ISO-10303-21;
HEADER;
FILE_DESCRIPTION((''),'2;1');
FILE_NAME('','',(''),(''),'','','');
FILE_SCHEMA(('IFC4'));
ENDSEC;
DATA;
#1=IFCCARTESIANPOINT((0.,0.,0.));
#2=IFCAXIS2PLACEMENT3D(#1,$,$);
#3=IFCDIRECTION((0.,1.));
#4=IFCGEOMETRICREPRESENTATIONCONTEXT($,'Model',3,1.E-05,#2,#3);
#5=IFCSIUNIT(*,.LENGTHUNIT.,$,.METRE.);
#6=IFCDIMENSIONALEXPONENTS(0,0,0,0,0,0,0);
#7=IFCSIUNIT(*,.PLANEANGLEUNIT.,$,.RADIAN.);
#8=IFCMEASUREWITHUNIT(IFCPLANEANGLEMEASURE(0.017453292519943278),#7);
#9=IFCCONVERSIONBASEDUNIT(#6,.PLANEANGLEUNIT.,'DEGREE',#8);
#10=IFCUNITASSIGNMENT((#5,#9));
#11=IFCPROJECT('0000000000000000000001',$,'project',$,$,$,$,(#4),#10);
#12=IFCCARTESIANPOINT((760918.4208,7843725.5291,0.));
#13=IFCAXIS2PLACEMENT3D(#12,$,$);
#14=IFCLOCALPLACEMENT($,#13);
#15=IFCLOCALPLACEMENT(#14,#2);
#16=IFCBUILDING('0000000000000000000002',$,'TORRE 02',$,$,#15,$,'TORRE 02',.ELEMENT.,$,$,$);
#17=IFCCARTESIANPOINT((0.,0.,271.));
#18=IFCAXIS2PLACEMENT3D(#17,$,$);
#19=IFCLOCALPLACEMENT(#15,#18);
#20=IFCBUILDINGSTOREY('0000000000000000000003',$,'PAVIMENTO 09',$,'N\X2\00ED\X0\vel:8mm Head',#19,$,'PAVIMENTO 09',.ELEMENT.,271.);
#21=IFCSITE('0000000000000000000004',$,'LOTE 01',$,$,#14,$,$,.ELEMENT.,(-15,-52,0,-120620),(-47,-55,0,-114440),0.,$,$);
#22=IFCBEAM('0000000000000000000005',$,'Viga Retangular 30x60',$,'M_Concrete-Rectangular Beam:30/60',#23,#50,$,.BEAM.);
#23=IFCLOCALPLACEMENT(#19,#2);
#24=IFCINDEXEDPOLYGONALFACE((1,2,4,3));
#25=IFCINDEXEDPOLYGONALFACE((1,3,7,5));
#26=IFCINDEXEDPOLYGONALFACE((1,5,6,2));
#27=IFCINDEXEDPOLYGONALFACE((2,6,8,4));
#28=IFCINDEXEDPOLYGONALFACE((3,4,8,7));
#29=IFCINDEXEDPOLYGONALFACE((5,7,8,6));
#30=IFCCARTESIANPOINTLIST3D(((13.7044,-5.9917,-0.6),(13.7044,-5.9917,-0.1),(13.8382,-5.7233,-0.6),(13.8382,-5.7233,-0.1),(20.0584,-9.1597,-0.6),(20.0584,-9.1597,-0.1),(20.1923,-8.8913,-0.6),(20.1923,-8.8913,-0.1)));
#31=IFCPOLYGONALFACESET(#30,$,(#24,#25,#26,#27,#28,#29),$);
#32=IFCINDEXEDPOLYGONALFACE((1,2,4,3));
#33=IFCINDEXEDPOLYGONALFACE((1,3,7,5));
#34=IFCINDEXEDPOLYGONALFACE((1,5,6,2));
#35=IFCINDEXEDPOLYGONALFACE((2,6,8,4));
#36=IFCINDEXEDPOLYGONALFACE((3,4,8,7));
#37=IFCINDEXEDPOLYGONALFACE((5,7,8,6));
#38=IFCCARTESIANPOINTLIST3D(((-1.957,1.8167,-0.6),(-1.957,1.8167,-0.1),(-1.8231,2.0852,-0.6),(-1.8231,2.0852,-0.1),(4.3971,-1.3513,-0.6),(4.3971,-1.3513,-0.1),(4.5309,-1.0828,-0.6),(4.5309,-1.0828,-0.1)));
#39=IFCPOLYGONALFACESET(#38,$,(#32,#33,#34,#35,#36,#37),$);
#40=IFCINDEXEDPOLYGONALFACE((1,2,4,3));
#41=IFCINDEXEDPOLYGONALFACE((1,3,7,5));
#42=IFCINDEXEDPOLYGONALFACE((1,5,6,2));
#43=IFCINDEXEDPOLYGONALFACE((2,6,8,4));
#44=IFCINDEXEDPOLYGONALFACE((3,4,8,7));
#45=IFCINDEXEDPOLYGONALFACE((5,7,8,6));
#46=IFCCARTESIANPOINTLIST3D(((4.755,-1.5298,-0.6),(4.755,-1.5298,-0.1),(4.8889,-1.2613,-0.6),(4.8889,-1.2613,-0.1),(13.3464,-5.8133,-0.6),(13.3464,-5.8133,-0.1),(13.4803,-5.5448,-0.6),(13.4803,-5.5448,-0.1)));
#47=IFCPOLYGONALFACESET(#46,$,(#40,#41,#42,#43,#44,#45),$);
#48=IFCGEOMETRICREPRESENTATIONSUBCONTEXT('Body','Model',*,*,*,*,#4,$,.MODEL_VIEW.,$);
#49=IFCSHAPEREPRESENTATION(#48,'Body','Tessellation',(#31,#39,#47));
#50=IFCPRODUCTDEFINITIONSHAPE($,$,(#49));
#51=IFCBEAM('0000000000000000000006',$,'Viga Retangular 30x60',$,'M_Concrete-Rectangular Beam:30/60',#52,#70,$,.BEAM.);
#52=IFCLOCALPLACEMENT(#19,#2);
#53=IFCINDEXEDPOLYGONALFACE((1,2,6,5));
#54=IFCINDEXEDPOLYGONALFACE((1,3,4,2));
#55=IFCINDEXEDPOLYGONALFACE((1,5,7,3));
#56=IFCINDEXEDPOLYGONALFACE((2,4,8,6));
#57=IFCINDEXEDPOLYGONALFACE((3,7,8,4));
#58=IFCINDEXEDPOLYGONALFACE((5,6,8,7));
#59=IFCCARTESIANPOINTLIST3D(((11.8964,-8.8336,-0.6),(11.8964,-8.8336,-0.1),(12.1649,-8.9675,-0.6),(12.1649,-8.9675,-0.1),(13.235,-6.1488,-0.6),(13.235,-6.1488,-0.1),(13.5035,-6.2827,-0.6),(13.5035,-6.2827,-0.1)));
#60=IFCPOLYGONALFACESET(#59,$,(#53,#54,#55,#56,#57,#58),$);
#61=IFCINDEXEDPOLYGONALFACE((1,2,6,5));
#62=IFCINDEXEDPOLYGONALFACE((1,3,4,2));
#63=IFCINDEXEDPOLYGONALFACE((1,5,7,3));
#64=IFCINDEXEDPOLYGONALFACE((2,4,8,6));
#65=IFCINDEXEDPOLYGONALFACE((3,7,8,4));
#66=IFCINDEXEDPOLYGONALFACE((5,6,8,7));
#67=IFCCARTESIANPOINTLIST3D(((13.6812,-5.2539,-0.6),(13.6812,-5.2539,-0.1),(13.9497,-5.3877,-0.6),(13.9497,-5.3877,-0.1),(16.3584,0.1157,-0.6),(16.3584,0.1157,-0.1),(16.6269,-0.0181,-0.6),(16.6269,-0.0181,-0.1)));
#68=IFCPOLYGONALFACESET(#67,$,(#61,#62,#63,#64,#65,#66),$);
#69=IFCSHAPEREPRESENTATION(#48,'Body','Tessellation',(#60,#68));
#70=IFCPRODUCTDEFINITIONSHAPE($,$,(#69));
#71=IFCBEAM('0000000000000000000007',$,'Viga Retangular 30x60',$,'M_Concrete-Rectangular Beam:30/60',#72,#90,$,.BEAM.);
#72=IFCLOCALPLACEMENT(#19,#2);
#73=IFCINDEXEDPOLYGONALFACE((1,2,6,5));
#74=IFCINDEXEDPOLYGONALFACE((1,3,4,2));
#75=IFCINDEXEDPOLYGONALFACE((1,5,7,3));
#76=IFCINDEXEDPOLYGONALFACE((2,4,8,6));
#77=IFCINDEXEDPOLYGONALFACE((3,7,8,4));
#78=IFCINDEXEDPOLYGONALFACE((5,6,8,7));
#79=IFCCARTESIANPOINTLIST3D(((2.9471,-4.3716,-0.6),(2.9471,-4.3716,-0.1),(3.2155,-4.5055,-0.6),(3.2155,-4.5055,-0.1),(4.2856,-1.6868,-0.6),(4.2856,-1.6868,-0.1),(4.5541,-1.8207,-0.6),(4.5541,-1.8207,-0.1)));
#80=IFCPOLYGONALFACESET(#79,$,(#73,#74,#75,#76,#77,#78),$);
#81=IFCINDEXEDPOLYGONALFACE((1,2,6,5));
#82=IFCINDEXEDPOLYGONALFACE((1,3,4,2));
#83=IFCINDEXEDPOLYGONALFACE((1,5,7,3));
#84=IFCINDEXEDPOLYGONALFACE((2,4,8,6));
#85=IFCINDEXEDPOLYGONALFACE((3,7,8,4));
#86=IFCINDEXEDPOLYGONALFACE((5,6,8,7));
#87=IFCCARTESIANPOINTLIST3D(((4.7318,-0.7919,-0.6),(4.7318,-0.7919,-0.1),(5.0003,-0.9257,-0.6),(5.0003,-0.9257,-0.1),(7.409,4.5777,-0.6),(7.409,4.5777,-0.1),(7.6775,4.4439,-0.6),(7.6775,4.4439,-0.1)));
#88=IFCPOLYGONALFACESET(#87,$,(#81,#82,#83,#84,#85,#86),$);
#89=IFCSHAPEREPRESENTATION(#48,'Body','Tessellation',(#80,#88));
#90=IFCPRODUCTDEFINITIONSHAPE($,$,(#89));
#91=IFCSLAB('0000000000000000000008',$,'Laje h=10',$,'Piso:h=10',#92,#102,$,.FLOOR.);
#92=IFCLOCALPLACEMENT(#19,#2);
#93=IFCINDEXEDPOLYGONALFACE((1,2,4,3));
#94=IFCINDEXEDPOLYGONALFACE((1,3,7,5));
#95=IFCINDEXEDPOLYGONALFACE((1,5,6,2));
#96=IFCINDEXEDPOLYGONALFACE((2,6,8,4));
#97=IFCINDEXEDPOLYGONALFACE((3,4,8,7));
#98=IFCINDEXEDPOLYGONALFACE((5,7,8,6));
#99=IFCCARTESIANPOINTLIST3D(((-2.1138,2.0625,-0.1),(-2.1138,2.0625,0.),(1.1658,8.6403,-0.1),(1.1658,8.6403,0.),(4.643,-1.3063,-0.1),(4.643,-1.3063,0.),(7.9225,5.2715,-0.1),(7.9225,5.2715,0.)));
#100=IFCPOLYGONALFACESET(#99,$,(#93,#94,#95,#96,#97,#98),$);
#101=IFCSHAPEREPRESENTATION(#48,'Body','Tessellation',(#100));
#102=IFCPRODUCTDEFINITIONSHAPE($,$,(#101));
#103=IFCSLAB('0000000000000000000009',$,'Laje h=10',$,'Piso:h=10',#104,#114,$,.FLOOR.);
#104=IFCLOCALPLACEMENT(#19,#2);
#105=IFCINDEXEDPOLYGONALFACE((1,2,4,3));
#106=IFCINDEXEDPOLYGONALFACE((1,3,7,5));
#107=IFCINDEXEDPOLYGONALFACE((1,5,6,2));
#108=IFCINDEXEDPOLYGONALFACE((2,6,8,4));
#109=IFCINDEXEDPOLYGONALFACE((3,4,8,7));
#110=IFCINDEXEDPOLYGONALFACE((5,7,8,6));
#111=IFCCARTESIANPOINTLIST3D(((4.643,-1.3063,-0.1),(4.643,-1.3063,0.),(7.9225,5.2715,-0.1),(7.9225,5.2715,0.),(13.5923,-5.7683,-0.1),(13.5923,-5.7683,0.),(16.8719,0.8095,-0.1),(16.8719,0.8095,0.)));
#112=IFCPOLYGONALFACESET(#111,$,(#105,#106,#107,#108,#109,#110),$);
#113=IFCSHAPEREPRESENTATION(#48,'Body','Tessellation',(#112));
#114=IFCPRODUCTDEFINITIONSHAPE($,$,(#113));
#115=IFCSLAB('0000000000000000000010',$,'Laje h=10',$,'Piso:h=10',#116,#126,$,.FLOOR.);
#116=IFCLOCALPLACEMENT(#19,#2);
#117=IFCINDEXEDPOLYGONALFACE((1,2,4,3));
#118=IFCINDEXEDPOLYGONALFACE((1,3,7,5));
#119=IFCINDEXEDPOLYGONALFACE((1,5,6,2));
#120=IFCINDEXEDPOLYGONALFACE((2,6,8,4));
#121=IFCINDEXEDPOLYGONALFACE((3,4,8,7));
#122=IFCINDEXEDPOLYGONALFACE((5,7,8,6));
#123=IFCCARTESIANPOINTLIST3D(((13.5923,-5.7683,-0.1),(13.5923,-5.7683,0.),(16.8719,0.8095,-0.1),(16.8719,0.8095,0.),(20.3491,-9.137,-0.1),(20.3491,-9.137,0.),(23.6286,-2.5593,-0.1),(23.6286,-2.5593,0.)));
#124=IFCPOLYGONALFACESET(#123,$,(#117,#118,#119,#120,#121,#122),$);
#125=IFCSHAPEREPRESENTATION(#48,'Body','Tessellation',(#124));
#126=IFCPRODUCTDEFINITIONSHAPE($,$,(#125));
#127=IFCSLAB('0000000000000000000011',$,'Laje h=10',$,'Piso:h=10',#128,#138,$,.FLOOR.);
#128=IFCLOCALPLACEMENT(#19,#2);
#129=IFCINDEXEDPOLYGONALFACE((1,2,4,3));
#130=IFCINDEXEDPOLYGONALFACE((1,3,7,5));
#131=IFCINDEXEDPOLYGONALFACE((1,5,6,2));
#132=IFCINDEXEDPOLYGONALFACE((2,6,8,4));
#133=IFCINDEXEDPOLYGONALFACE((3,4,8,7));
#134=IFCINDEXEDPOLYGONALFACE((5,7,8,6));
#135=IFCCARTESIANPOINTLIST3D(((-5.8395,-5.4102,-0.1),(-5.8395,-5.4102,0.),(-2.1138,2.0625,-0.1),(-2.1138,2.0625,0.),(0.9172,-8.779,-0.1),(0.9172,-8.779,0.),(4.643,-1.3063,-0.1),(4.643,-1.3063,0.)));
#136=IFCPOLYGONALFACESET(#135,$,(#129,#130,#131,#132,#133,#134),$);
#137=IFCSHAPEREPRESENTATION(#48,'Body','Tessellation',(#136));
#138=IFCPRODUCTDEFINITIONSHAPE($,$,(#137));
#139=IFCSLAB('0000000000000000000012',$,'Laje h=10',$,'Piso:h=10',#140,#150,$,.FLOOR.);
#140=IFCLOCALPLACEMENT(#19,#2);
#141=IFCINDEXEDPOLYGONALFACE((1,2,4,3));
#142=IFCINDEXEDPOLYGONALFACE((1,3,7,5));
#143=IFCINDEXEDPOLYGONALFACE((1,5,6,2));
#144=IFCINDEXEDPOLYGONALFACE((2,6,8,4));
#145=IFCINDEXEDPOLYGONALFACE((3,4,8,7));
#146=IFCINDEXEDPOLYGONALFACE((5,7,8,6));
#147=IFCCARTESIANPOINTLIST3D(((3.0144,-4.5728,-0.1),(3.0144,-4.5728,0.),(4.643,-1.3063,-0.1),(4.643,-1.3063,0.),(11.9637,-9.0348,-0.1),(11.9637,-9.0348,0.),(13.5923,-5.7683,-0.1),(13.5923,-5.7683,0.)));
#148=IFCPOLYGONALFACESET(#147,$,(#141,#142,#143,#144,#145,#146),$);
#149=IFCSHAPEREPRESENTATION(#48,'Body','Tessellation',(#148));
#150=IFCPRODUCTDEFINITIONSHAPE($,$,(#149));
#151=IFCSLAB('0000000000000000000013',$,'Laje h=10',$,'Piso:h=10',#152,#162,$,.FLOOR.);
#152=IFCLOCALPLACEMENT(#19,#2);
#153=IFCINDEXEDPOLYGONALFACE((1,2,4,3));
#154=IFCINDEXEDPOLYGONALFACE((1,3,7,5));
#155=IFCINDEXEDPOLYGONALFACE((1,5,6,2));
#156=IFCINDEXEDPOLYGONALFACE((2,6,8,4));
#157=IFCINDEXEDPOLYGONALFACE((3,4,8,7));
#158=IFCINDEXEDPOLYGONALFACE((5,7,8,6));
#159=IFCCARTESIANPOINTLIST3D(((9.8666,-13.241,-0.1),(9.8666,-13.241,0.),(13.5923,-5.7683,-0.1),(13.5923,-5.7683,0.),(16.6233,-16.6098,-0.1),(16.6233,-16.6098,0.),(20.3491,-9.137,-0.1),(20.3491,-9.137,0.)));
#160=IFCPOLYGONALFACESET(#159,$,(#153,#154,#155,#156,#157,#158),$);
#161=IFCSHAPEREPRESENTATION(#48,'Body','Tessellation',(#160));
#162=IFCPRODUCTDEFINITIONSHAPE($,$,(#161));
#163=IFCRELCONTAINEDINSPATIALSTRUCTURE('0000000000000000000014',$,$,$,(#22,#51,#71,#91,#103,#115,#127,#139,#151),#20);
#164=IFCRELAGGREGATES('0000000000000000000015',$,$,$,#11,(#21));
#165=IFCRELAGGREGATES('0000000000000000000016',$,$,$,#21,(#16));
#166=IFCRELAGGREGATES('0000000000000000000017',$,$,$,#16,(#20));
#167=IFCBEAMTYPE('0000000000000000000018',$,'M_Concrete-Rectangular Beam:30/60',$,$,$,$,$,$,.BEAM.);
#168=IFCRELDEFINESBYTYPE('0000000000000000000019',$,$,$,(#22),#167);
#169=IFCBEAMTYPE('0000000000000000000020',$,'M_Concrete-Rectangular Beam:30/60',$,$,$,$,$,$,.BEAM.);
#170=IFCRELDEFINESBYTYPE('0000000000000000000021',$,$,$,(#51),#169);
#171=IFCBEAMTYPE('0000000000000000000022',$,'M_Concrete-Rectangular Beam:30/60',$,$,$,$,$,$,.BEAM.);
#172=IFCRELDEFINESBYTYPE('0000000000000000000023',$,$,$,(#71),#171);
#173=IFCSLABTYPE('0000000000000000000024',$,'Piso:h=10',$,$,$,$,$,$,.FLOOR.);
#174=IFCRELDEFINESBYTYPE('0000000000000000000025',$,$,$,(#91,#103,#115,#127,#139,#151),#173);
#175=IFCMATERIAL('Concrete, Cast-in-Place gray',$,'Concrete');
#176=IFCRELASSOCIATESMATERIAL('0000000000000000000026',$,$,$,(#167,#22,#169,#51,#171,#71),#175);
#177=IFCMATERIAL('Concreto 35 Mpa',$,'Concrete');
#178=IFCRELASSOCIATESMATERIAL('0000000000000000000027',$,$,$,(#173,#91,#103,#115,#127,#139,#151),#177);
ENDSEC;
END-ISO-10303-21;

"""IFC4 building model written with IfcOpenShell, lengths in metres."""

from ifc_helpers import new_model, entity, si_unit, converted_unit, direction, frame, origin, place, context, subcontext, project, spatial, indexed_curve, outline, extrude, source, transform, mapped, material, type_object, type_shapes, element, save


model = new_model("IFC4")

# Units and contexts
model_context = context("Model", 3, precision=1e-05, world=origin(), true_north=direction((0.0, 1.0)))
body_context = subcontext(model_context, "Body", "Model", "MODEL_VIEW")
ifc_project = project(units=[si_unit("LENGTHUNIT", "METRE"), converted_unit("PLANEANGLEUNIT", "DEGREE", entity("IfcPlaneAngleMeasure", 0.017453292519943278), si_unit("PLANEANGLEUNIT", "RADIAN"), dimensions=[0, 0, 0, 0, 0, 0, 0])], contexts=[model_context])

# Site, building, storey
site_placement = place(None, frame((760918.4208, 7843725.5291, 0.0)))
site = spatial("IfcSite", under=ifc_project, at=site_placement, Name="LOTE 01", CompositionType="ELEMENT", RefLatitude=(-15, -52, 0, -120620), RefLongitude=(-47, -55, 0, -114440), RefElevation=0.0)
building_placement = place(site_placement, origin())
building = spatial("IfcBuilding", under=site, at=building_placement, Name="TORRE 02", LongName="TORRE 02", CompositionType="ELEMENT")
storey_placement = place(building_placement, frame((0.0, 0.0, 271.0)))
storey = spatial("IfcBuildingStorey", under=building, at=storey_placement, Name="PAVIMENTO 09", ObjectType="Nível:8mm Head", LongName="PAVIMENTO 09", CompositionType="ELEMENT", Elevation=271.0)

# Shared definitions
ifc_material_1 = material(Name="Concrete, Cast-in-Place gray", Category="Concrete")

# Beams
beam_type_1 = type_object("IfcBeamType", Name="M_Concrete-Rectangular Beam:30/60", PredefinedType="BEAM", material=ifc_material_1)
shared_shape_1 = source(origin(), body_context, "Body", "SweptSolid", [
    extrude(outline(indexed_curve([(-0.25, -0.15), (0.25, -0.15), (0.25, 0.15), (-0.25, 0.15), (-0.25, -0.15)], self_intersect=False)), frame((13.7713, -5.8575, 270.65), z_axis=(0.894934, -0.446198, 0.0), x_axis=(0.0, 0.0, -1.0)), (0.0, 0.0, 1.0), 7.1),
    extrude(outline(indexed_curve([(-0.25, -0.15), (0.25, -0.15), (0.25, 0.15), (-0.25, 0.15), (-0.25, -0.15)], self_intersect=False)), frame((-1.89, 1.951, 270.65), z_axis=(0.894934, -0.446198, 0.0), x_axis=(0.0, 0.0, -1.0)), (0.0, 0.0, 1.0), 7.1),
    extrude(outline(indexed_curve([(-0.25, -0.15), (0.25, -0.15), (0.25, 0.15), (-0.25, 0.15), (-0.25, -0.15)], self_intersect=False)), frame((4.822, -1.3955, 270.65), z_axis=(0.894934, -0.446198, 0.0), x_axis=(0.0, 0.0, -1.0)), (0.0, 0.0, 1.0), 9.6),
])
type_shapes(beam_type_1, [shared_shape_1])
beam_1_placement = place(storey_placement, frame((0.0, 0.0, -271.0)))
element("IfcBeam", 1, at=beam_1_placement, inside=storey, type_object=beam_type_1, material=ifc_material_1, Name="Viga Retangular 30x60", ObjectType="M_Concrete-Rectangular Beam:30/60", PredefinedType="BEAM", context=body_context, shape_type="MappedRepresentation", body=[
    mapped(shared_shape_1, transform((0.0, 0.0, 0.0), scale=1.0)),
])
beam_type_2 = type_object("IfcBeamType", Name="M_Concrete-Rectangular Beam:30/60", PredefinedType="BEAM", material=ifc_material_1)
shared_shape_2 = source(origin(), body_context, "Body", "SweptSolid", [
    extrude(outline(indexed_curve([(-0.25, -0.15), (0.25, -0.15), (0.25, 0.15), (-0.25, 0.15), (-0.25, -0.15)], self_intersect=False)), frame((12.0306, -8.9005, 270.65), z_axis=(0.446198, 0.894934, 0.0), x_axis=(0.0, 0.0, 1.0)), (0.0, 0.0, 1.0), 3.0),
    extrude(outline(indexed_curve([(-0.25, -0.15), (0.25, -0.15), (0.25, 0.15), (-0.25, 0.15), (-0.25, -0.15)], self_intersect=False)), frame((13.8154, -5.3208, 270.65), z_axis=(0.446198, 0.894934, 0.0), x_axis=(0.0, 0.0, 1.0)), (0.0, 0.0, 1.0), 6.0),
])
type_shapes(beam_type_2, [shared_shape_2])
beam_2_placement = place(storey_placement, frame((0.0, 0.0, -271.0)))
element("IfcBeam", 2, at=beam_2_placement, inside=storey, type_object=beam_type_2, material=ifc_material_1, Name="Viga Retangular 30x60", ObjectType="M_Concrete-Rectangular Beam:30/60", PredefinedType="BEAM", context=body_context, shape_type="MappedRepresentation", body=[
    mapped(shared_shape_2, transform((0.0, 0.0, 0.0), scale=1.0)),
])
beam_type_3 = type_object("IfcBeamType", Name="M_Concrete-Rectangular Beam:30/60", PredefinedType="BEAM", material=ifc_material_1)
shared_shape_3 = source(origin(), body_context, "Body", "SweptSolid", [
    extrude(outline(indexed_curve([(-0.25, -0.15), (0.25, -0.15), (0.25, 0.15), (-0.25, 0.15), (-0.25, -0.15)], self_intersect=False)), frame((3.0813, -4.4385, 270.65), z_axis=(0.446198, 0.894934, 0.0), x_axis=(0.0, 0.0, 1.0)), (0.0, 0.0, 1.0), 3.0),
    extrude(outline(indexed_curve([(-0.25, -0.15), (0.25, -0.15), (0.25, 0.15), (-0.25, 0.15), (-0.25, -0.15)], self_intersect=False)), frame((4.8661, -0.8588, 270.65), z_axis=(0.446198, 0.894934, 0.0), x_axis=(0.0, 0.0, 1.0)), (0.0, 0.0, 1.0), 6.0),
])
type_shapes(beam_type_3, [shared_shape_3])
beam_3_placement = place(storey_placement, frame((0.0, 0.0, -271.0)))
element("IfcBeam", 3, at=beam_3_placement, inside=storey, type_object=beam_type_3, material=ifc_material_1, Name="Viga Retangular 30x60", ObjectType="M_Concrete-Rectangular Beam:30/60", PredefinedType="BEAM", context=body_context, shape_type="MappedRepresentation", body=[
    mapped(shared_shape_3, transform((0.0, 0.0, 0.0), scale=1.0)),
])

# Slabs
ifc_material_2 = material(Name="Concreto 35 Mpa", Category="Concrete")
slab_type = type_object("IfcSlabType", Name="Piso:h=10", PredefinedType="FLOOR", material=ifc_material_2)
slab_1_placement = place(storey_placement, origin())
element("IfcSlab", 4, at=slab_1_placement, inside=storey, type_object=slab_type, material=ifc_material_2, Name="Laje h=10", ObjectType="Piso:h=10", PredefinedType="FLOOR", context=body_context, shape_type="SweptSolid", body=[
    extrude(outline(indexed_curve([(-3.675, -3.775), (3.675, -3.775), (3.675, 3.775), (-3.675, 3.775), (-3.675, -3.775)], self_intersect=False)), frame((2.9044, 3.667, 0.0), z_axis=(0.0, 0.0, -1.0), x_axis=(-0.446198, -0.894934, 0.0)), (0.0, 0.0, 1.0), 0.1),
])
slab_2_placement = place(storey_placement, origin())
element("IfcSlab", 5, at=slab_2_placement, inside=storey, type_object=slab_type, material=ifc_material_2, Name="Laje h=10", ObjectType="Piso:h=10", PredefinedType="FLOOR", context=body_context, shape_type="SweptSolid", body=[
    extrude(outline(indexed_curve([(-3.675, -5.0), (3.675, -5.0), (3.675, 5.0), (-3.675, 5.0), (-3.675, -5.0)], self_intersect=False)), frame((10.7574, -0.2484, 0.0), z_axis=(0.0, 0.0, -1.0), x_axis=(-0.446198, -0.894934, 0.0)), (0.0, 0.0, 1.0), 0.1),
])
slab_3_placement = place(storey_placement, origin())
element("IfcSlab", 6, at=slab_3_placement, inside=storey, type_object=slab_type, material=ifc_material_2, Name="Laje h=10", ObjectType="Piso:h=10", PredefinedType="FLOOR", context=body_context, shape_type="SweptSolid", body=[
    extrude(outline(indexed_curve([(-3.675, -3.775), (3.675, -3.775), (3.675, 3.775), (-3.675, 3.775), (-3.675, -3.775)], self_intersect=False)), frame((18.6105, -4.1638, 0.0), z_axis=(0.0, 0.0, -1.0), x_axis=(-0.446198, -0.894934, 0.0)), (0.0, 0.0, 1.0), 0.1),
])
slab_4_placement = place(storey_placement, origin())
element("IfcSlab", 7, at=slab_4_placement, inside=storey, type_object=slab_type, material=ifc_material_2, Name="Laje h=10", ObjectType="Piso:h=10", PredefinedType="FLOOR", context=body_context, shape_type="SweptSolid", body=[
    extrude(outline(indexed_curve([(-4.175, -3.775), (4.175, -3.775), (4.175, 3.775), (-4.175, 3.775), (-4.175, -3.775)], self_intersect=False)), frame((-0.5983, -3.3582, 0.0), z_axis=(0.0, 0.0, -1.0), x_axis=(-0.446198, -0.894934, 0.0)), (0.0, 0.0, 1.0), 0.1),
])
slab_5_placement = place(storey_placement, origin())
element("IfcSlab", 8, at=slab_5_placement, inside=storey, type_object=slab_type, material=ifc_material_2, Name="Laje h=10", ObjectType="Piso:h=10", PredefinedType="FLOOR", context=body_context, shape_type="SweptSolid", body=[
    extrude(outline(indexed_curve([(-1.825, -5.0), (1.825, -5.0), (1.825, 5.0), (-1.825, 5.0), (-1.825, -5.0)], self_intersect=False)), frame((8.3033, -5.1705, 0.0), z_axis=(0.0, 0.0, -1.0), x_axis=(-0.446198, -0.894934, 0.0)), (0.0, 0.0, 1.0), 0.1),
])
slab_6_placement = place(storey_placement, origin())
element("IfcSlab", 9, at=slab_6_placement, inside=storey, type_object=slab_type, material=ifc_material_2, Name="Laje h=10", ObjectType="Piso:h=10", PredefinedType="FLOOR", context=body_context, shape_type="SweptSolid", body=[
    extrude(outline(indexed_curve([(-4.175, -3.775), (4.175, -3.775), (4.175, 3.775), (-4.175, 3.775), (-4.175, -3.775)], self_intersect=False)), frame((15.1078, -11.189, 0.0), z_axis=(0.0, 0.0, -1.0), x_axis=(-0.446198, -0.894934, 0.0)), (0.0, 0.0, 1.0), 0.1),
])

save(model, "model.ifc")
